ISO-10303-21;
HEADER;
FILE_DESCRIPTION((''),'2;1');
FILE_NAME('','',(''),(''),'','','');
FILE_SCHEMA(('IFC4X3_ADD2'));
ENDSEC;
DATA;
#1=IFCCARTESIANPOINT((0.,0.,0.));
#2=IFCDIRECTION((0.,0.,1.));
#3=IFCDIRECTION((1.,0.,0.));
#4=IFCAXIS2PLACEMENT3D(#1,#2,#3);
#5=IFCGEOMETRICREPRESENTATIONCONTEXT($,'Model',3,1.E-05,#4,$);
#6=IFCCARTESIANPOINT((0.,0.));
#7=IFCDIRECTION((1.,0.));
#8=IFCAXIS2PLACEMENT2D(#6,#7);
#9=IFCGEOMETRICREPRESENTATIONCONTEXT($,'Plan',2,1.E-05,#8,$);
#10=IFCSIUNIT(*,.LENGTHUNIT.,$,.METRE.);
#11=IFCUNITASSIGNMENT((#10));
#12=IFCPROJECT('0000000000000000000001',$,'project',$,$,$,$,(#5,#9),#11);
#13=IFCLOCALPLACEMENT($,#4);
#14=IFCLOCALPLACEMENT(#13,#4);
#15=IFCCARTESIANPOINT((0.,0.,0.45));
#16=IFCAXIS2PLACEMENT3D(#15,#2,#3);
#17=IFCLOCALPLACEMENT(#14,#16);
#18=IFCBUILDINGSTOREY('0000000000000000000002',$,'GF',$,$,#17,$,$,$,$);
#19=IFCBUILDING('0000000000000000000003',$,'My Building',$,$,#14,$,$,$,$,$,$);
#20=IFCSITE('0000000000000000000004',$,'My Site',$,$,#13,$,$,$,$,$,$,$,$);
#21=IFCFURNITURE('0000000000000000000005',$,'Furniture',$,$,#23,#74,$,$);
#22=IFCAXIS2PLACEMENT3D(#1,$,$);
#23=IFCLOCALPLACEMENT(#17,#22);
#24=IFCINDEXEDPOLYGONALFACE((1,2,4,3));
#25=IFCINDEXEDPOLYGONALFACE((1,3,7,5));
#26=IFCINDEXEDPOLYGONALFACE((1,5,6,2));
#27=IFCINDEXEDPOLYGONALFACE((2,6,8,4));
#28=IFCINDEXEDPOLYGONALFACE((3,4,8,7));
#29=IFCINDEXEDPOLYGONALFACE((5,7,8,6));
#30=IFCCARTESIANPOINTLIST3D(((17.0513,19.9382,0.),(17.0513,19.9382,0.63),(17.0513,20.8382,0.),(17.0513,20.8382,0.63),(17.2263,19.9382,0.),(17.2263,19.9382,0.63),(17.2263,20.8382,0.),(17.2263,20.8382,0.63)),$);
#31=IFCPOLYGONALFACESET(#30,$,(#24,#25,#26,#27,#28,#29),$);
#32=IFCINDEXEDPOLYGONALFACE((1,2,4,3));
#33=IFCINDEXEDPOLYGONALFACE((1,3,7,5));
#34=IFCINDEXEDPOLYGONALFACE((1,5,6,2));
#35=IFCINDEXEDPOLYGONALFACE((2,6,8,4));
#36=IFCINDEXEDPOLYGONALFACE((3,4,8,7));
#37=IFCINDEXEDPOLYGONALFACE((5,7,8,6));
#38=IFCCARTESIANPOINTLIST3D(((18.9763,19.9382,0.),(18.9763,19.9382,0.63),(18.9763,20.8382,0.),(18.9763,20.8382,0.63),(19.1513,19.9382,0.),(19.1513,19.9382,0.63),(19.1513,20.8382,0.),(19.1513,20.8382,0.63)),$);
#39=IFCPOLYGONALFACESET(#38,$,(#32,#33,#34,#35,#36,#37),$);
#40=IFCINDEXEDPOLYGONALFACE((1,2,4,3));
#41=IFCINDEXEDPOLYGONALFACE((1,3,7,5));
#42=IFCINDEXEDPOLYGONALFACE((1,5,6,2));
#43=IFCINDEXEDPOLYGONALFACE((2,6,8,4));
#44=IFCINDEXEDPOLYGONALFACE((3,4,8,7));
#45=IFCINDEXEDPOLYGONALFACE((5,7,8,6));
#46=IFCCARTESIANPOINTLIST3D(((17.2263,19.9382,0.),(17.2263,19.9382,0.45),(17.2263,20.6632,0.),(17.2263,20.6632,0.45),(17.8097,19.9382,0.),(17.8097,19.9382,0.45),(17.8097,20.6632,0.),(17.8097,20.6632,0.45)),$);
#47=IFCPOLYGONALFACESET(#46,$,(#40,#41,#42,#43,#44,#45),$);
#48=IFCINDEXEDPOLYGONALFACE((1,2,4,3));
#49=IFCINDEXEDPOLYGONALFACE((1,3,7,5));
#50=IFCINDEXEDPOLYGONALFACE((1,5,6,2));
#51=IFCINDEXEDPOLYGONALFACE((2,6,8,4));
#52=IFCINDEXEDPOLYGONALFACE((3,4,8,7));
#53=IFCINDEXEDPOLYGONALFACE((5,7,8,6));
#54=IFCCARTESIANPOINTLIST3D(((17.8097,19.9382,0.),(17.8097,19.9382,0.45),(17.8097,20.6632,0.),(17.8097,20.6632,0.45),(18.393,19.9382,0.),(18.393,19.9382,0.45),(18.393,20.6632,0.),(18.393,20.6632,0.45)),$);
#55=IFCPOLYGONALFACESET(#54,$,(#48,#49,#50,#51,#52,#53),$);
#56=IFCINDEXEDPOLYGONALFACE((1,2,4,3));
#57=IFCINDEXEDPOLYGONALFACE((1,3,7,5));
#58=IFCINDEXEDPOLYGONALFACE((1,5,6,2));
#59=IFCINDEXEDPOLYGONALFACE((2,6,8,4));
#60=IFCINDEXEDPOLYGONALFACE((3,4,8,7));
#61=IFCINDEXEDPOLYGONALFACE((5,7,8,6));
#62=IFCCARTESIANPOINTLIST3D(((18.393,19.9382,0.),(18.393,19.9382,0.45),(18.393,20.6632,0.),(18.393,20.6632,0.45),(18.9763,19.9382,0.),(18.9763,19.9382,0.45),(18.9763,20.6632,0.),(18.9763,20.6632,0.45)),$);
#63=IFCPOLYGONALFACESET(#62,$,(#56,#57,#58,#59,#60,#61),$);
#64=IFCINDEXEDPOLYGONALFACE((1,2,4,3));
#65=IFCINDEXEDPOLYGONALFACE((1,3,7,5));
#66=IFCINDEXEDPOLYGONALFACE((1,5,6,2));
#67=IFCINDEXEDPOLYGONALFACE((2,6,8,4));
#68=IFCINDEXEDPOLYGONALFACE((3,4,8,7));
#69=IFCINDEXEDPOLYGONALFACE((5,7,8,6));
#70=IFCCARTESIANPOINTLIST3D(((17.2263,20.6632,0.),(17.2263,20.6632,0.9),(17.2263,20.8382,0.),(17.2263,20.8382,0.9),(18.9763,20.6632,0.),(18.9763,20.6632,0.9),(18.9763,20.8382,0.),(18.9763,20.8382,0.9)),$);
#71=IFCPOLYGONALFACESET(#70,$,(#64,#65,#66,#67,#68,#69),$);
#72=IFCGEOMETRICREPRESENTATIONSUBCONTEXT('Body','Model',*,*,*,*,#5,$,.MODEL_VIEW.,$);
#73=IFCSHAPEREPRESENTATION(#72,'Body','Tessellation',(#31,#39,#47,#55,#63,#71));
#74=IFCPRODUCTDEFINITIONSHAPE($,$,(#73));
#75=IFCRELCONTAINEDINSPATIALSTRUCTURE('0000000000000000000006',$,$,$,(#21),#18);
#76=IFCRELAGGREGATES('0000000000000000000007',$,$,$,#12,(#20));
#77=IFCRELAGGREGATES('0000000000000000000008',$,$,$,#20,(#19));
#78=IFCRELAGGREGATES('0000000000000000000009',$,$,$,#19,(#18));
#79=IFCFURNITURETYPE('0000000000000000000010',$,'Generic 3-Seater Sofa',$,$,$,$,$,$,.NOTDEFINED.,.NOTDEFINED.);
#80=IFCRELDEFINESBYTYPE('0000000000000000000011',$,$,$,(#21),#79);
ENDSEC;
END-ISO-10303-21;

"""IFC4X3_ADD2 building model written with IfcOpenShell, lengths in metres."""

from ifc_helpers import new_model, entity, si_unit, frame, origin_with_axes, origin_2d_with_axis, place, context, subcontext, project, spatial, line, indexed_curve, outline, extrude, shape, source, transform, mapped, type_object, type_shapes, element, save


model = new_model("IFC4X3_ADD2")

# Units and contexts
model_context = context("Model", 3, precision=1e-05, world=origin_with_axes())
plan_context = context("Plan", 2, precision=1e-05, world=origin_2d_with_axis())
body_context_1 = subcontext(model_context, "Body", "Model", "MODEL_VIEW")
body_context_2 = subcontext(plan_context, "Body", "Plan", "PLAN_VIEW")
ifc_project = project(units=[si_unit("LENGTHUNIT", "METRE")], contexts=[model_context, plan_context])

# Site, building, storey
site_placement = place(None, origin_with_axes())
site = spatial("IfcSite", under=ifc_project, at=site_placement, Name="My Site")
building_placement = place(site_placement, origin_with_axes())
building = spatial("IfcBuilding", under=site, at=building_placement, Name="My Building")
storey_placement = place(building_placement, frame((0.0, 0.0, 0.45), z_axis=(0.0, 0.0, 1.0), x_axis=(1.0, 0.0, 0.0)))
storey = spatial("IfcBuildingStorey", under=building, at=storey_placement, Name="GF")

# Furniture
furniture_type = type_object("IfcFurnitureType", Name="Generic 3-Seater Sofa", AssemblyPlace="NOTDEFINED", PredefinedType="NOTDEFINED")
shared_shape_1 = source(origin_with_axes(), body_context_1, "Body", "SweptSolid", [
    extrude(outline(indexed_curve([(0.0, 0.0), (0.175, 0.0), (0.175, 0.9), (0.0, 0.9)], segments=[line(4, 1), line(1, 2), line(2, 3), line(3, 4)], self_intersect=False)), frame((-1.05, -0.9, 0.0), z_axis=(0.0, 0.0, 1.0), x_axis=(1.0, 0.0, 0.0)), (0.0, 0.0, 1.0), 0.63),
    extrude(outline(indexed_curve([(0.0, 0.0), (0.175, 0.0), (0.175, 0.9), (0.0, 0.9)], segments=[line(1, 2, 3, 4, 1)])), frame((0.875, -0.9, 0.0), z_axis=(0.0, 0.0, 1.0), x_axis=(1.0, 0.0, 0.0)), (0.0, 0.0, 1.0), 0.63),
    extrude(outline(indexed_curve([(0.175, 0.0), (0.7583, 0.0), (0.7583, 0.725), (0.175, 0.725)], segments=[line(1, 2, 3, 4, 1)])), frame((-1.05, -0.9, 0.0), z_axis=(0.0, 0.0, 1.0), x_axis=(1.0, 0.0, 0.0)), (0.0, 0.0, 1.0), 0.45),
    extrude(outline(indexed_curve([(0.7583, 0.0), (1.3417, 0.0), (1.3417, 0.725), (0.7583, 0.725)], segments=[line(1, 2, 3, 4, 1)])), frame((-1.05, -0.9, 0.0), z_axis=(0.0, 0.0, 1.0), x_axis=(1.0, 0.0, 0.0)), (0.0, 0.0, 1.0), 0.45),
    extrude(outline(indexed_curve([(1.3417, 0.0), (1.925, 0.0), (1.925, 0.725), (1.3417, 0.725)], segments=[line(1, 2, 3, 4, 1)])), frame((-1.05, -0.9, 0.0), z_axis=(0.0, 0.0, 1.0), x_axis=(1.0, 0.0, 0.0)), (0.0, 0.0, 1.0), 0.45),
    extrude(outline(indexed_curve([(0.175, 0.725), (1.925, 0.725), (1.925, 0.9), (0.175, 0.9)], segments=[line(1, 2, 3, 4, 1)])), frame((-1.05, -0.9, 0.0), z_axis=(0.0, 0.0, 1.0), x_axis=(1.0, 0.0, 0.0)), (0.0, 0.0, 1.0), 0.9),
])
shared_shape_2 = source(origin_with_axes(), body_context_2, "Body", "Annotation2D", [
    entity("IfcGeometricCurveSet", [entity("IfcIndexedPolyCurve", entity("IfcCartesianPointList2D", [[0.2917, -0.175], [0.2917, -0.9], [0.875, -0.9], [0.875, -0.175], [-0.875, -0.175], [-0.875, 0.0], [0.875, 0.0], [1.05, 0.0], [1.05, -0.9], [0.875, -0.9], [0.875, 0.0], [0.875, -0.175], [0.2917, -0.175], [-0.2917, -0.175], [-0.2917, -0.9], [-0.875, -0.9], [-0.875, 0.0], [-1.05, 0.0], [-1.05, -0.9], [-0.875, -0.9], [-0.875, -0.175], [-0.2917, -0.175]])), entity("IfcIndexedPolyCurve", entity("IfcCartesianPointList2D", [[0.2917, -0.9], [-0.2917, -0.9]]))]),
])
type_shapes(furniture_type, [shared_shape_1, shared_shape_2])
furniture_placement = place(storey_placement, frame((18.1013, 20.8382, 0.0), z_axis=(0.0, 0.0, 1.0), x_axis=(1.0, 0.0, 0.0)))
element("IfcFurniture", 1, at=furniture_placement, inside=storey, type_object=furniture_type, Name="Furniture", shapes=[
    shape(body_context_1, "Body", "MappedRepresentation", [mapped(shared_shape_1, transform((0.0, 0.0, 0.0), x_axis=(1.0, 0.0, 0.0), y_axis=(0.0, 1.0, 0.0), z_axis=(0.0, 0.0, 1.0), scale=1.0))]),
    shape(body_context_2, "Body", "MappedRepresentation", [mapped(shared_shape_2, transform((0.0, 0.0, 0.0), x_axis=(1.0, 0.0, 0.0), y_axis=(0.0, 1.0, 0.0), z_axis=(0.0, 0.0, 1.0), scale=1.0))]),
])

save(model, "model.ifc")
